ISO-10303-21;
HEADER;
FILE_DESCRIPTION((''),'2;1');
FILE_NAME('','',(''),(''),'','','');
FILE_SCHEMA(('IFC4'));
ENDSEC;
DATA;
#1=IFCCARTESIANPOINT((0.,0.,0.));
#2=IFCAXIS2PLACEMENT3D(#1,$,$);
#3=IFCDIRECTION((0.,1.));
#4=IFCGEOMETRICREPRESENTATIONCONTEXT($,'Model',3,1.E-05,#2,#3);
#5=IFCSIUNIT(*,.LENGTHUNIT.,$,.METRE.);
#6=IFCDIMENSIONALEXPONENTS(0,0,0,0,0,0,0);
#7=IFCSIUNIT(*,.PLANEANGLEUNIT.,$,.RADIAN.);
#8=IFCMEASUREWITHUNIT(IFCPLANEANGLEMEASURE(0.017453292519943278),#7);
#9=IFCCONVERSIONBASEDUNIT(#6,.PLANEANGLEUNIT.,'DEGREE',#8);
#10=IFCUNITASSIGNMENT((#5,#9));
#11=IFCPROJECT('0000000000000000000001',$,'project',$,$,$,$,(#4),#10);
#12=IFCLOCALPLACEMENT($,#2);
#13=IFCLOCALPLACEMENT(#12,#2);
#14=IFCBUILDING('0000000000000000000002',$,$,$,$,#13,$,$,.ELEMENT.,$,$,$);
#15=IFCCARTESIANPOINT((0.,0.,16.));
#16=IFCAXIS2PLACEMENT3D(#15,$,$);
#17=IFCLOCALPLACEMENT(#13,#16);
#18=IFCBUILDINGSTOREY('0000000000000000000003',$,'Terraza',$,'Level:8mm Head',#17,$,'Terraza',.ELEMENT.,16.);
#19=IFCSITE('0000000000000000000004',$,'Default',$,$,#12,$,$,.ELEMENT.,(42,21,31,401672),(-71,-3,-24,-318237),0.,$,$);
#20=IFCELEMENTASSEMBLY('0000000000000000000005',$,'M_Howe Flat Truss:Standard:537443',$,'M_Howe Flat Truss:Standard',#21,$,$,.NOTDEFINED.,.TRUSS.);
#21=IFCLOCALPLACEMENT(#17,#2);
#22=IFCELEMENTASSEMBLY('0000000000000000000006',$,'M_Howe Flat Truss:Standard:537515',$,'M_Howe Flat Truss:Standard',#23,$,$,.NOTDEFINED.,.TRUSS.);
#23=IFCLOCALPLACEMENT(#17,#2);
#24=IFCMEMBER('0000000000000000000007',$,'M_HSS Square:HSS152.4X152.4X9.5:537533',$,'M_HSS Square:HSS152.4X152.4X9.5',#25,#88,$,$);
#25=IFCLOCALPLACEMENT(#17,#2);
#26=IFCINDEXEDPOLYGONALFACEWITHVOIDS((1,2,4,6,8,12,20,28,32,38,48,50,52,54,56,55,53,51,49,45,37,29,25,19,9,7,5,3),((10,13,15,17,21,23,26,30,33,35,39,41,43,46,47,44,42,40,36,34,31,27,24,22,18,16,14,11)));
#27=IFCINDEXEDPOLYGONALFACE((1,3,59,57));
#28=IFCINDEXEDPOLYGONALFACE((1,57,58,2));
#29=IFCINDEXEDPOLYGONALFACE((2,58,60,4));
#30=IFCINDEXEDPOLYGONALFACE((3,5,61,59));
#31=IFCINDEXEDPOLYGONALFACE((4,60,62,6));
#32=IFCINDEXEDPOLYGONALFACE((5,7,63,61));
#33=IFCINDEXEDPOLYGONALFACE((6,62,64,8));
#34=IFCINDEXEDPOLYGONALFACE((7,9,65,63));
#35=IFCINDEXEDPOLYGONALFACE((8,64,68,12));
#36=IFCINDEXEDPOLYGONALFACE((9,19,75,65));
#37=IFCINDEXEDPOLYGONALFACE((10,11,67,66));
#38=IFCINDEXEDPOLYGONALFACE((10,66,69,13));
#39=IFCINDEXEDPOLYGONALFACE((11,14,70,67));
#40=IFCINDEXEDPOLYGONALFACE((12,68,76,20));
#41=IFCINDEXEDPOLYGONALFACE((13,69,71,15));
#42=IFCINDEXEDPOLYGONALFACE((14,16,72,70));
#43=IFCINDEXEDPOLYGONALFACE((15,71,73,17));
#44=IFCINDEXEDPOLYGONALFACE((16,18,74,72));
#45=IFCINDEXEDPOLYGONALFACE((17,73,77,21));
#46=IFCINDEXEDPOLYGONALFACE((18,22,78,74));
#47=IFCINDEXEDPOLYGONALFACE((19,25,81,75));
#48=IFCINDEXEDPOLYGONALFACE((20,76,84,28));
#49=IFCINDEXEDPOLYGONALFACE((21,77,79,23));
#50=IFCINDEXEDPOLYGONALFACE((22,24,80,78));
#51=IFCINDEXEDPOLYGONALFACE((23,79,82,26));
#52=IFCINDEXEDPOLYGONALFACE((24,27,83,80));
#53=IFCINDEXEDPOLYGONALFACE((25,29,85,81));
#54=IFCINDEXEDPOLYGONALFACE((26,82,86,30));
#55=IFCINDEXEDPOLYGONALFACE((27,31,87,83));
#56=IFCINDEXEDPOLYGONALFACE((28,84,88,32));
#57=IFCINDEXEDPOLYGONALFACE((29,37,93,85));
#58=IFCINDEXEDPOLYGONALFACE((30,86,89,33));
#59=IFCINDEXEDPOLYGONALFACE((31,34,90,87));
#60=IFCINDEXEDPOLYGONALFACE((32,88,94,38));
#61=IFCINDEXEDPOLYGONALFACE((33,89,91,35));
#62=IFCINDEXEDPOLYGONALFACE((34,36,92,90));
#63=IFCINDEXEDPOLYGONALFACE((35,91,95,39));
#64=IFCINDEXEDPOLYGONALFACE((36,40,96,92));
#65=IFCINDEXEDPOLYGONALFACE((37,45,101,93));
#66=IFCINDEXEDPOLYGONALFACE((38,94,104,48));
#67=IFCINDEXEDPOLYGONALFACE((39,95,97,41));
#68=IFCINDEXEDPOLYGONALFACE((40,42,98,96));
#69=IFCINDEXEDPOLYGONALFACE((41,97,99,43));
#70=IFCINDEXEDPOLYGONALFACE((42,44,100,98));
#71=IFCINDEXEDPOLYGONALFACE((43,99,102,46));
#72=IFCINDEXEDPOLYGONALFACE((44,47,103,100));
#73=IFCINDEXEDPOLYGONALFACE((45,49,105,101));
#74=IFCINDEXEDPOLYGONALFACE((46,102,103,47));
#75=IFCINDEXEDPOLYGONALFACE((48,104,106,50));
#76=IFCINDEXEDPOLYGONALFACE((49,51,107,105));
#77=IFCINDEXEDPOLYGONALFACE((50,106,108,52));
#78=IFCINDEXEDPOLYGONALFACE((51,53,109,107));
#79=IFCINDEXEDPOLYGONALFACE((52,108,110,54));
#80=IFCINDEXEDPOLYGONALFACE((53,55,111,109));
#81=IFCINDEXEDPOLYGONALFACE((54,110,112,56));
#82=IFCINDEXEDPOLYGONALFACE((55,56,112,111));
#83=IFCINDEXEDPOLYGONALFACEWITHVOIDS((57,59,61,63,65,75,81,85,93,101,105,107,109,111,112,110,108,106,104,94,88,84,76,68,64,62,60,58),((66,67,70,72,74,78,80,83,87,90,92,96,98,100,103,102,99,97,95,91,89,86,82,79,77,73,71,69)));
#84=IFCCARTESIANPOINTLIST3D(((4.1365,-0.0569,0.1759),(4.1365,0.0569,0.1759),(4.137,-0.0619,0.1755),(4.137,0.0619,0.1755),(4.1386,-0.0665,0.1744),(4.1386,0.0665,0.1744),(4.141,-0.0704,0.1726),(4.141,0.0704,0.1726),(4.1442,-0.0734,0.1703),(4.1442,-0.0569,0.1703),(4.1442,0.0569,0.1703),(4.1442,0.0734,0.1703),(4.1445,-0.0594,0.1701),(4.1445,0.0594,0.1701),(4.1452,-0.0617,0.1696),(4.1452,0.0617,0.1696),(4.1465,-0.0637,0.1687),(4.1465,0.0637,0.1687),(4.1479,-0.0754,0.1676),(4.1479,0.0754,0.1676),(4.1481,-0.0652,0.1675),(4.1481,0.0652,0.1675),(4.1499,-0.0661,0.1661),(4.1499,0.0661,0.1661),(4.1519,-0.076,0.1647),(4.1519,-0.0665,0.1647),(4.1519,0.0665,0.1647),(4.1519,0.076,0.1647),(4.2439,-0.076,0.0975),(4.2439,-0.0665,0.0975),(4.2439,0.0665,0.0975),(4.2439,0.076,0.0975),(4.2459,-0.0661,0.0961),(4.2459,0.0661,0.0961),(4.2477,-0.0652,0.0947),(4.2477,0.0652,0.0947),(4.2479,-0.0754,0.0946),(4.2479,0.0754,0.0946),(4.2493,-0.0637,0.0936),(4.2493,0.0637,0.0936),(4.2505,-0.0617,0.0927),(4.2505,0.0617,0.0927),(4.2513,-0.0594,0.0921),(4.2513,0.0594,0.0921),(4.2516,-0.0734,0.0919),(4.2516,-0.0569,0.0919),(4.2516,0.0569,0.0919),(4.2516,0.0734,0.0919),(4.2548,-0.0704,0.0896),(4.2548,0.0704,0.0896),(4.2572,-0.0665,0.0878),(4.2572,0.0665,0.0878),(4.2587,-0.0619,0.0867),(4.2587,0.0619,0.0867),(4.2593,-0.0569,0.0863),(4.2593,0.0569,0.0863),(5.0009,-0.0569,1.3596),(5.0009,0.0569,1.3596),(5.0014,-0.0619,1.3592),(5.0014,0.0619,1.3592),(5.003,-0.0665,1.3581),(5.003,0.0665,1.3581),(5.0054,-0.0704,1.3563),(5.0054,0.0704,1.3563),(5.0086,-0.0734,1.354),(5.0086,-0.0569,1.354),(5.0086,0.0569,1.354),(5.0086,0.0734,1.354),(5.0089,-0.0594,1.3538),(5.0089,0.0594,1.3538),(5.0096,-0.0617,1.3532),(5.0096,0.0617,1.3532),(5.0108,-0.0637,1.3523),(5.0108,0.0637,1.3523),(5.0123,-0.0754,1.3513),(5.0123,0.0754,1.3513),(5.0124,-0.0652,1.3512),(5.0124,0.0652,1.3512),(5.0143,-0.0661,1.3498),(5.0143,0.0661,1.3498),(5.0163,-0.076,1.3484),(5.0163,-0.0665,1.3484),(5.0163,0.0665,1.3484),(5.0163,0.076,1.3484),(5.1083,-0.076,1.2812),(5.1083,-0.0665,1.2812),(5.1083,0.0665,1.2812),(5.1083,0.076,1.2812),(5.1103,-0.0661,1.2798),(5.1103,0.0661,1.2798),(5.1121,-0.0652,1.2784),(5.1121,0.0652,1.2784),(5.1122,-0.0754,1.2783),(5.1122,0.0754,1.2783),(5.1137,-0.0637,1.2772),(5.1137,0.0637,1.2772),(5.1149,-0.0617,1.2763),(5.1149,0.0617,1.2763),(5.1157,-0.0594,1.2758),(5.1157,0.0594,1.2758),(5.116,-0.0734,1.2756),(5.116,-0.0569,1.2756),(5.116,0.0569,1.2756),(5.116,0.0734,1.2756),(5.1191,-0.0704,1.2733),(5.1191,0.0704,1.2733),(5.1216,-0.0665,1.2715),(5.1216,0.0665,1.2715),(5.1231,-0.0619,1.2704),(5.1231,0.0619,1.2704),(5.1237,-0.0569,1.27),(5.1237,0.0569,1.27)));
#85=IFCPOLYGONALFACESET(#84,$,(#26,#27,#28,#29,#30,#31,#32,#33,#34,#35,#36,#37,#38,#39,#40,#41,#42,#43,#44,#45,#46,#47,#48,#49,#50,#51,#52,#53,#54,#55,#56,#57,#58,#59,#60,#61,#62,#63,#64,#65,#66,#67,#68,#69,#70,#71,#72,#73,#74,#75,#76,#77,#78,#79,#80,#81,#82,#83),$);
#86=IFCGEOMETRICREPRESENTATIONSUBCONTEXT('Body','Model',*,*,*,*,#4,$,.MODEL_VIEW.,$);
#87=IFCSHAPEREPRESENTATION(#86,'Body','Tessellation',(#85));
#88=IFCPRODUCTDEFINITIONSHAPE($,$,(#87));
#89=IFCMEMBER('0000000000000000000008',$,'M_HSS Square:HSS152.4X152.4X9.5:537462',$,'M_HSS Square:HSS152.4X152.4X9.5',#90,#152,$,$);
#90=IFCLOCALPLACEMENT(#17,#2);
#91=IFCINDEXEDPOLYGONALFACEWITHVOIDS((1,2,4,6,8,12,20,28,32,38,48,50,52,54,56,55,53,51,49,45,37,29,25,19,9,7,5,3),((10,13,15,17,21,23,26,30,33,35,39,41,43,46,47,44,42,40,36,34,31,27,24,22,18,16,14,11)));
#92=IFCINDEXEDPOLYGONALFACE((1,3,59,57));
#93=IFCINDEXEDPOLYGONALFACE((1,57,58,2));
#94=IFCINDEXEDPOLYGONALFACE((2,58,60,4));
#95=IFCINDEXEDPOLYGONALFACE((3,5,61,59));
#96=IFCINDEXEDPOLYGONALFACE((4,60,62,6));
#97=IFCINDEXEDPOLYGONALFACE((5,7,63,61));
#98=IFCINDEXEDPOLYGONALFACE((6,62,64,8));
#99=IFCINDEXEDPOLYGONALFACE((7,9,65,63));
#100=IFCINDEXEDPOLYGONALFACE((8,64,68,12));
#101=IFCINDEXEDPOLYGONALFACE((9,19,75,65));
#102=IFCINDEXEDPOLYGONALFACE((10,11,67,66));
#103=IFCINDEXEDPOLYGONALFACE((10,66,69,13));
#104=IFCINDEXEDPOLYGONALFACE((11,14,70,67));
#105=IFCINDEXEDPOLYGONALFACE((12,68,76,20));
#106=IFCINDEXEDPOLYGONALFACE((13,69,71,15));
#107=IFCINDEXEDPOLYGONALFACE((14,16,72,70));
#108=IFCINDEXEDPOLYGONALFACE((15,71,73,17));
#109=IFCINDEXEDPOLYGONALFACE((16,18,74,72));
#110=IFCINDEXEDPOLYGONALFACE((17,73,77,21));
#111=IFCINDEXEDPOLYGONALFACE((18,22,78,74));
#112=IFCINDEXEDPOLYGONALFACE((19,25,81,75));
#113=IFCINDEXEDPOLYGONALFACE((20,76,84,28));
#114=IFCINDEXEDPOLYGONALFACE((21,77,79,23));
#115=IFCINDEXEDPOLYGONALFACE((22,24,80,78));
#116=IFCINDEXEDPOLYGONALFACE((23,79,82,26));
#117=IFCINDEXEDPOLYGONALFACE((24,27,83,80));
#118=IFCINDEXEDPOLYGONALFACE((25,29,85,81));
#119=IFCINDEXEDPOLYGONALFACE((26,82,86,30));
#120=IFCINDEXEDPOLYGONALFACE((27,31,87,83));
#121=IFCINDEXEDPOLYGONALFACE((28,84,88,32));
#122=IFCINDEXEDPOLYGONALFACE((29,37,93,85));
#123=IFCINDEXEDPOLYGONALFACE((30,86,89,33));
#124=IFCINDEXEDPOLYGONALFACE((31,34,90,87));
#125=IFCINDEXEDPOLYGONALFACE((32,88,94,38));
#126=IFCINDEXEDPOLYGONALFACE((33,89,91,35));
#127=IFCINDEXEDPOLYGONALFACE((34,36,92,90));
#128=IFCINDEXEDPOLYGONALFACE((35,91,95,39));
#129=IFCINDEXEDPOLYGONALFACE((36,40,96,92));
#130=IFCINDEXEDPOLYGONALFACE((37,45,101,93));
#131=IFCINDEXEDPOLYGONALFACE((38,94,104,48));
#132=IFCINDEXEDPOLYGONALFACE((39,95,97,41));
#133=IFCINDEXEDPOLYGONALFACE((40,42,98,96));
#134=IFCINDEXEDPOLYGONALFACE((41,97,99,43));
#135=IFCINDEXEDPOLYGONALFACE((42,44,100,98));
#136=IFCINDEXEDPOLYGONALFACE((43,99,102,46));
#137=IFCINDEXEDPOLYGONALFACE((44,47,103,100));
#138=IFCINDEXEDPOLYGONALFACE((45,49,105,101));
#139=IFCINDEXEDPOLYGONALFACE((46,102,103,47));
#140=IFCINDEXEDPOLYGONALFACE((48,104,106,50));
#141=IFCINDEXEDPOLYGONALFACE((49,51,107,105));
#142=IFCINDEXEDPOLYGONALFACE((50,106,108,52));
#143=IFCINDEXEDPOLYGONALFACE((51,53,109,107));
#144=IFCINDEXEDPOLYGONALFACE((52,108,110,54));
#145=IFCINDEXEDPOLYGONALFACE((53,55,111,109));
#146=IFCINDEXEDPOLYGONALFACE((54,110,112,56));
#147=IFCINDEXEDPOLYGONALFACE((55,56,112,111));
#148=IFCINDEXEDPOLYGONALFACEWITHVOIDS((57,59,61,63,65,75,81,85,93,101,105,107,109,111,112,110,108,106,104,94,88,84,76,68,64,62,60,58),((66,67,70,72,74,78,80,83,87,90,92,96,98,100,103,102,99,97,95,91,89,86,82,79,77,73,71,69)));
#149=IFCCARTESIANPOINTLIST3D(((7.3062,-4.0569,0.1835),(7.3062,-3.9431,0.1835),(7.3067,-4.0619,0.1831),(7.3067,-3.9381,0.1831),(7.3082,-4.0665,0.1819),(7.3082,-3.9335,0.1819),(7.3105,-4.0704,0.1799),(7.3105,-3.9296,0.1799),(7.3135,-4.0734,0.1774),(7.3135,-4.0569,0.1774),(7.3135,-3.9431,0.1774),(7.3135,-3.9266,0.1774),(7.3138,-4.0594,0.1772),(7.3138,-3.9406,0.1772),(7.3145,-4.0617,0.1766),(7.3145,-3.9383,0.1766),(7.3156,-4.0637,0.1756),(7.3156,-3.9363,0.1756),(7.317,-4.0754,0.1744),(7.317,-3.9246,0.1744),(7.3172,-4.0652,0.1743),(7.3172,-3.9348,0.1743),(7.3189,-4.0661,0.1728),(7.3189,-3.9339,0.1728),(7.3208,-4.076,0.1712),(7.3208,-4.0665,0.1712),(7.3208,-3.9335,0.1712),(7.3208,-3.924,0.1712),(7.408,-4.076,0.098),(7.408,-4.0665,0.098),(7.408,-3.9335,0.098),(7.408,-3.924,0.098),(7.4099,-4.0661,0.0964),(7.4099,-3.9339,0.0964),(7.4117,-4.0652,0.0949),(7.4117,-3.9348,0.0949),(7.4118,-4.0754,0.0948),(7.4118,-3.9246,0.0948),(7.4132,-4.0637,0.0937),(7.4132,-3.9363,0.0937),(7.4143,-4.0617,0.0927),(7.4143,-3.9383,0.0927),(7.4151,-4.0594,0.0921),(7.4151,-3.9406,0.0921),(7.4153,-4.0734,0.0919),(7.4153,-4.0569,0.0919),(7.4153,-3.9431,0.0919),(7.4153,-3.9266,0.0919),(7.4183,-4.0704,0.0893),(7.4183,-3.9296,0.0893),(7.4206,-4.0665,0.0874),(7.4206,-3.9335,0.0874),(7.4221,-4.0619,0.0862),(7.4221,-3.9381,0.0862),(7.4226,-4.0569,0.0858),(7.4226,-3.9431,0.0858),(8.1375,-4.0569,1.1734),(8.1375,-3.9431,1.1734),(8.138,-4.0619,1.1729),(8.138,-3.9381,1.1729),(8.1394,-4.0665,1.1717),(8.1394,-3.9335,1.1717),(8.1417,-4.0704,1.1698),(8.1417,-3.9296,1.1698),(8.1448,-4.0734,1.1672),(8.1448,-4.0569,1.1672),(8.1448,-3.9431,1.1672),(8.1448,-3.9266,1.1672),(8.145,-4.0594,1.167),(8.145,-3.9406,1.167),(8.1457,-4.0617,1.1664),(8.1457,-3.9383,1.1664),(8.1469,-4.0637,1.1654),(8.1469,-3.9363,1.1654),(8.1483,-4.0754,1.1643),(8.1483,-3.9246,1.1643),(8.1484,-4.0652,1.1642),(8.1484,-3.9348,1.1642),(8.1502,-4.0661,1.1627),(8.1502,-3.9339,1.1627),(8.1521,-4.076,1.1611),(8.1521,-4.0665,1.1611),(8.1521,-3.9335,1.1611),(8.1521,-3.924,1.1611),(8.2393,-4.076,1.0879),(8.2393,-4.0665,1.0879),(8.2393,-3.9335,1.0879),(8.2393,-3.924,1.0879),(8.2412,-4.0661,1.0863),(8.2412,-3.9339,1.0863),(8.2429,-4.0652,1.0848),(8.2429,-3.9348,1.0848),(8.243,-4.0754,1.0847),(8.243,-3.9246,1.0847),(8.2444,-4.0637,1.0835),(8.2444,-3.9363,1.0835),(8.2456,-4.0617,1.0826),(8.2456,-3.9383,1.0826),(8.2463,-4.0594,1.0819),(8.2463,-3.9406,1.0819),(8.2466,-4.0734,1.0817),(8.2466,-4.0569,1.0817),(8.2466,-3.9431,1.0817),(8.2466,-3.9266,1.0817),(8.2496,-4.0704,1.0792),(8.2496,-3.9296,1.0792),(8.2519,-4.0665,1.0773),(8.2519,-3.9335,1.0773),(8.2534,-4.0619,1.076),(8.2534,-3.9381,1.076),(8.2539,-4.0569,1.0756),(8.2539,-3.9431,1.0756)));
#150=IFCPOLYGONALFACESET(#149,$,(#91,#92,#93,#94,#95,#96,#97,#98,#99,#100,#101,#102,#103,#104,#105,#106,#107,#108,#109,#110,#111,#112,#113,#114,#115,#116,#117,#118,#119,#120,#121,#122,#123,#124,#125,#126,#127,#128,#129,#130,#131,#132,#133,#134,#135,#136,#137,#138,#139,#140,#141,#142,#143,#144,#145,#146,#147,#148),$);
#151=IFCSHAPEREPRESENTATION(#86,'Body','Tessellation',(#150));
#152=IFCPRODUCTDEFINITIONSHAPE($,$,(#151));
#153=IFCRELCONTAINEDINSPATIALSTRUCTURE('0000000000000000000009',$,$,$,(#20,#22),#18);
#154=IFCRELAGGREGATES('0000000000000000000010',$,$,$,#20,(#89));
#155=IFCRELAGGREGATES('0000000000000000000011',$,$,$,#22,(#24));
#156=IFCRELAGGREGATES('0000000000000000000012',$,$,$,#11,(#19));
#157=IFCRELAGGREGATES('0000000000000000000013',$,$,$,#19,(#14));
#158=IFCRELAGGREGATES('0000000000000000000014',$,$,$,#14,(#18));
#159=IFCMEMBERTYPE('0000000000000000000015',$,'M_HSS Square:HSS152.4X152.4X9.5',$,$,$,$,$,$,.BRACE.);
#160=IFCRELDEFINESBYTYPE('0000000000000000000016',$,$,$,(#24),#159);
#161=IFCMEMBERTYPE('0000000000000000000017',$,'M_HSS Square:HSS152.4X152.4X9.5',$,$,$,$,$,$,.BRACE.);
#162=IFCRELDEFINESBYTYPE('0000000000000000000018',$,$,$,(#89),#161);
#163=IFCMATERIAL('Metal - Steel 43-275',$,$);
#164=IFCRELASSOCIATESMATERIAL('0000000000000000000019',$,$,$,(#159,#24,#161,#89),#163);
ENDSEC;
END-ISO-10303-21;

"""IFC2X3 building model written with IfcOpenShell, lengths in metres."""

from ifc_helpers import new_model, entity, si_unit, converted_unit, direction, frame, frame_2d, origin, place, context, subcontext, project, spatial, polyline, circle_curve, parameter, trimmed, segment, composite_curve, outline, extrude, source, transform, mapped, material, type_object, type_shapes, element, aggregate, save


model = new_model("IFC2X3")

# Units and contexts
model_context = context("Model", 3, precision=1e-05, world=origin(), true_north=direction((0.0, 1.0)))
body_context = subcontext(model_context, "Body", "Model", "MODEL_VIEW")
ifc_project = project(units=[si_unit("LENGTHUNIT", "METRE"), converted_unit("PLANEANGLEUNIT", "DEGREE", entity("IfcPlaneAngleMeasure", 0.017453292519943278), si_unit("PLANEANGLEUNIT", "RADIAN"), dimensions=[0, 0, 0, 0, 0, 0, 0])], contexts=[model_context])

# Site, building, storey
site_placement = place(None, origin())
site = spatial("IfcSite", under=ifc_project, at=site_placement, Name="Default", CompositionType="ELEMENT", RefLatitude=(42, 21, 31, 401672), RefLongitude=(-71, -3, -24, -318237), RefElevation=0.0)
building_placement = place(site_placement, origin())
building = spatial("IfcBuilding", under=site, at=building_placement, CompositionType="ELEMENT")
storey_placement = place(building_placement, frame((0.0, 0.0, 16.0)))
storey = spatial("IfcBuildingStorey", under=building, at=storey_placement, Name="Terraza", ObjectType="Level:8mm Head", LongName="Terraza", CompositionType="ELEMENT", Elevation=16.0)

# Element assemblies
ifc_material_1 = material(Name="Metal - Steel 43-275")
assembly_1_placement = place(storey_placement, origin())
assembly_1 = element("IfcElementAssembly", 1, at=assembly_1_placement, inside=storey, Name="M_Howe Flat Truss:Standard:537443", ObjectType="M_Howe Flat Truss:Standard", AssemblyPlace="NOTDEFINED", PredefinedType="TRUSS")
assembly_2_placement = place(storey_placement, origin())
assembly_2 = element("IfcElementAssembly", 2, at=assembly_2_placement, inside=storey, Name="M_Howe Flat Truss:Standard:537515", ObjectType="M_Howe Flat Truss:Standard", AssemblyPlace="NOTDEFINED", PredefinedType="TRUSS")

# Members
member_type_1 = type_object("IfcMemberType", Name="M_HSS Square:HSS152.4X152.4X9.5", PredefinedType="BRACE", material=ifc_material_1)
shared_shape_1 = source(origin(), body_context, "Body", "SweptSolid", [
    extrude(outline(composite_curve([segment(polyline([(-0.0569, -0.076), (0.0569, -0.076)]), True, "CONTINUOUS"), segment(trimmed(circle_curve(frame_2d((0.0569, -0.0569), x_axis=(0.0, 1.0)), 0.0191), [parameter(180.0)], [parameter(270.0)], True, "PARAMETER"), True, "CONTINUOUS"), segment(polyline([(0.076, -0.0569), (0.076, 0.0569)]), True, "CONTINUOUS"), segment(trimmed(circle_curve(frame_2d((0.0569, 0.0569), x_axis=(0.0, 1.0)), 0.0191), [parameter(270.0)], [parameter(0.0)], True, "PARAMETER"), True, "CONTINUOUS"), segment(polyline([(0.0569, 0.076), (-0.0569, 0.076)]), True, "CONTINUOUS"), segment(trimmed(circle_curve(frame_2d((-0.0569, 0.0569), x_axis=(0.0, 1.0)), 0.0191), [parameter(0.0)], [parameter(90.0)], True, "PARAMETER"), True, "CONTINUOUS"), segment(polyline([(-0.076, 0.0569), (-0.076, -0.0569)]), True, "CONTINUOUS"), segment(trimmed(circle_curve(frame_2d((-0.0569, -0.0569), x_axis=(0.0, 1.0)), 0.0191), [parameter(90.0)], [parameter(180.0)], True, "PARAMETER"), True, "CONTINUOUS")], self_intersect=False), holes=[composite_curve([segment(trimmed(circle_curve(frame_2d((-0.0569, 0.0569), x_axis=(0.0, 1.0)), 0.0095), [parameter(360.0)], [parameter(90.0)], True, "PARAMETER"), False, "CONTINUOUS"), segment(polyline([(-0.0569, 0.0665), (0.0569, 0.0665)]), True, "CONTINUOUS"), segment(trimmed(circle_curve(frame_2d((0.0569, 0.0569), x_axis=(0.0, 1.0)), 0.0095), [parameter(270.0)], [parameter(360.0)], True, "PARAMETER"), False, "CONTINUOUS"), segment(polyline([(0.0665, 0.0569), (0.0665, -0.0569)]), True, "CONTINUOUS"), segment(trimmed(circle_curve(frame_2d((0.0569, -0.0569), x_axis=(0.0, 1.0)), 0.0095), [parameter(180.0)], [parameter(270.0)], True, "PARAMETER"), False, "CONTINUOUS"), segment(polyline([(0.0569, -0.0665), (-0.0569, -0.0665)]), True, "CONTINUOUS"), segment(trimmed(circle_curve(frame_2d((-0.0569, -0.0569), x_axis=(0.0, 1.0)), 0.0095), [parameter(90.0)], [parameter(180.0)], True, "PARAMETER"), False, "CONTINUOUS"), segment(polyline([(-0.0665, -0.0569), (-0.0665, 0.0569)]), True, "CONTINUOUS")], self_intersect=False)]), frame((-0.7277, 0.0, 0.0), z_axis=(1.0, 0.0, 0.0), x_axis=(0.0, 0.0, -1.0)), (0.0, 0.0, 1.0), 1.4657),
])
type_shapes(member_type_1, [shared_shape_1])
member_1_placement = place(assembly_2_placement, frame((4.627, 0.0, 0.7187), z_axis=(0.807592, 0.0, -0.589742), x_axis=(0.589742, 0.0, 0.807592)))
member_1 = element("IfcMember", 3, at=member_1_placement, type_object=member_type_1, material=ifc_material_1, Name="M_HSS Square:HSS152.4X152.4X9.5:537533", ObjectType="M_HSS Square:HSS152.4X152.4X9.5", context=body_context, shape_type="MappedRepresentation", body=[
    mapped(shared_shape_1, transform((0.0, 0.0, 0.0), scale=1.0)),
])
member_type_2 = type_object("IfcMemberType", Name="M_HSS Square:HSS152.4X152.4X9.5", PredefinedType="BRACE", material=ifc_material_1)
shared_shape_2 = source(origin(), body_context, "Body", "SweptSolid", [
    extrude(outline(composite_curve([segment(polyline([(-0.0569, -0.076), (0.0569, -0.076)]), True, "CONTINUOUS"), segment(trimmed(circle_curve(frame_2d((0.0569, -0.0569), x_axis=(0.0, 1.0)), 0.0191), [parameter(180.0)], [parameter(270.0)], True, "PARAMETER"), True, "CONTINUOUS"), segment(polyline([(0.076, -0.0569), (0.076, 0.0569)]), True, "CONTINUOUS"), segment(trimmed(circle_curve(frame_2d((0.0569, 0.0569), x_axis=(0.0, 1.0)), 0.0191), [parameter(270.0)], [parameter(0.0)], True, "PARAMETER"), True, "CONTINUOUS"), segment(polyline([(0.0569, 0.076), (-0.0569, 0.076)]), True, "CONTINUOUS"), segment(trimmed(circle_curve(frame_2d((-0.0569, 0.0569), x_axis=(0.0, 1.0)), 0.0191), [parameter(0.0)], [parameter(90.0)], True, "PARAMETER"), True, "CONTINUOUS"), segment(polyline([(-0.076, 0.0569), (-0.076, -0.0569)]), True, "CONTINUOUS"), segment(trimmed(circle_curve(frame_2d((-0.0569, -0.0569), x_axis=(0.0, 1.0)), 0.0191), [parameter(90.0)], [parameter(180.0)], True, "PARAMETER"), True, "CONTINUOUS")], self_intersect=False), holes=[composite_curve([segment(trimmed(circle_curve(frame_2d((-0.0569, 0.0569), x_axis=(0.0, 1.0)), 0.0095), [parameter(360.0)], [parameter(90.0)], True, "PARAMETER"), False, "CONTINUOUS"), segment(polyline([(-0.0569, 0.0665), (0.0569, 0.0665)]), True, "CONTINUOUS"), segment(trimmed(circle_curve(frame_2d((0.0569, 0.0569), x_axis=(0.0, 1.0)), 0.0095), [parameter(270.0)], [parameter(360.0)], True, "PARAMETER"), False, "CONTINUOUS"), segment(polyline([(0.0665, 0.0569), (0.0665, -0.0569)]), True, "CONTINUOUS"), segment(trimmed(circle_curve(frame_2d((0.0569, -0.0569), x_axis=(0.0, 1.0)), 0.0095), [parameter(180.0)], [parameter(270.0)], True, "PARAMETER"), False, "CONTINUOUS"), segment(polyline([(0.0569, -0.0665), (-0.0569, -0.0665)]), True, "CONTINUOUS"), segment(trimmed(circle_curve(frame_2d((-0.0569, -0.0569), x_axis=(0.0, 1.0)), 0.0095), [parameter(90.0)], [parameter(180.0)], True, "PARAMETER"), False, "CONTINUOUS"), segment(polyline([(-0.0665, -0.0569), (-0.0665, 0.0569)]), True, "CONTINUOUS")], self_intersect=False)]), frame((-0.6404, 0.0, 0.0), z_axis=(1.0, 0.0, 0.0), x_axis=(0.0, 0.0, -1.0)), (0.0, 0.0, 1.0), 1.2926),
])
type_shapes(member_type_2, [shared_shape_2])
member_2_placement = place(assembly_1_placement, frame((7.7762, -4.0, 0.625), z_axis=(0.765786, 0.0, -0.643096), x_axis=(0.643096, 0.0, 0.765786)))
member_2 = element("IfcMember", 4, at=member_2_placement, type_object=member_type_2, material=ifc_material_1, Name="M_HSS Square:HSS152.4X152.4X9.5:537462", ObjectType="M_HSS Square:HSS152.4X152.4X9.5", context=body_context, shape_type="MappedRepresentation", body=[
    mapped(shared_shape_2, transform((0.0, 0.0, 0.0), scale=1.0)),
])
aggregate(assembly_1, [member_2])
aggregate(assembly_2, [member_1])

save(model, "model.ifc")
